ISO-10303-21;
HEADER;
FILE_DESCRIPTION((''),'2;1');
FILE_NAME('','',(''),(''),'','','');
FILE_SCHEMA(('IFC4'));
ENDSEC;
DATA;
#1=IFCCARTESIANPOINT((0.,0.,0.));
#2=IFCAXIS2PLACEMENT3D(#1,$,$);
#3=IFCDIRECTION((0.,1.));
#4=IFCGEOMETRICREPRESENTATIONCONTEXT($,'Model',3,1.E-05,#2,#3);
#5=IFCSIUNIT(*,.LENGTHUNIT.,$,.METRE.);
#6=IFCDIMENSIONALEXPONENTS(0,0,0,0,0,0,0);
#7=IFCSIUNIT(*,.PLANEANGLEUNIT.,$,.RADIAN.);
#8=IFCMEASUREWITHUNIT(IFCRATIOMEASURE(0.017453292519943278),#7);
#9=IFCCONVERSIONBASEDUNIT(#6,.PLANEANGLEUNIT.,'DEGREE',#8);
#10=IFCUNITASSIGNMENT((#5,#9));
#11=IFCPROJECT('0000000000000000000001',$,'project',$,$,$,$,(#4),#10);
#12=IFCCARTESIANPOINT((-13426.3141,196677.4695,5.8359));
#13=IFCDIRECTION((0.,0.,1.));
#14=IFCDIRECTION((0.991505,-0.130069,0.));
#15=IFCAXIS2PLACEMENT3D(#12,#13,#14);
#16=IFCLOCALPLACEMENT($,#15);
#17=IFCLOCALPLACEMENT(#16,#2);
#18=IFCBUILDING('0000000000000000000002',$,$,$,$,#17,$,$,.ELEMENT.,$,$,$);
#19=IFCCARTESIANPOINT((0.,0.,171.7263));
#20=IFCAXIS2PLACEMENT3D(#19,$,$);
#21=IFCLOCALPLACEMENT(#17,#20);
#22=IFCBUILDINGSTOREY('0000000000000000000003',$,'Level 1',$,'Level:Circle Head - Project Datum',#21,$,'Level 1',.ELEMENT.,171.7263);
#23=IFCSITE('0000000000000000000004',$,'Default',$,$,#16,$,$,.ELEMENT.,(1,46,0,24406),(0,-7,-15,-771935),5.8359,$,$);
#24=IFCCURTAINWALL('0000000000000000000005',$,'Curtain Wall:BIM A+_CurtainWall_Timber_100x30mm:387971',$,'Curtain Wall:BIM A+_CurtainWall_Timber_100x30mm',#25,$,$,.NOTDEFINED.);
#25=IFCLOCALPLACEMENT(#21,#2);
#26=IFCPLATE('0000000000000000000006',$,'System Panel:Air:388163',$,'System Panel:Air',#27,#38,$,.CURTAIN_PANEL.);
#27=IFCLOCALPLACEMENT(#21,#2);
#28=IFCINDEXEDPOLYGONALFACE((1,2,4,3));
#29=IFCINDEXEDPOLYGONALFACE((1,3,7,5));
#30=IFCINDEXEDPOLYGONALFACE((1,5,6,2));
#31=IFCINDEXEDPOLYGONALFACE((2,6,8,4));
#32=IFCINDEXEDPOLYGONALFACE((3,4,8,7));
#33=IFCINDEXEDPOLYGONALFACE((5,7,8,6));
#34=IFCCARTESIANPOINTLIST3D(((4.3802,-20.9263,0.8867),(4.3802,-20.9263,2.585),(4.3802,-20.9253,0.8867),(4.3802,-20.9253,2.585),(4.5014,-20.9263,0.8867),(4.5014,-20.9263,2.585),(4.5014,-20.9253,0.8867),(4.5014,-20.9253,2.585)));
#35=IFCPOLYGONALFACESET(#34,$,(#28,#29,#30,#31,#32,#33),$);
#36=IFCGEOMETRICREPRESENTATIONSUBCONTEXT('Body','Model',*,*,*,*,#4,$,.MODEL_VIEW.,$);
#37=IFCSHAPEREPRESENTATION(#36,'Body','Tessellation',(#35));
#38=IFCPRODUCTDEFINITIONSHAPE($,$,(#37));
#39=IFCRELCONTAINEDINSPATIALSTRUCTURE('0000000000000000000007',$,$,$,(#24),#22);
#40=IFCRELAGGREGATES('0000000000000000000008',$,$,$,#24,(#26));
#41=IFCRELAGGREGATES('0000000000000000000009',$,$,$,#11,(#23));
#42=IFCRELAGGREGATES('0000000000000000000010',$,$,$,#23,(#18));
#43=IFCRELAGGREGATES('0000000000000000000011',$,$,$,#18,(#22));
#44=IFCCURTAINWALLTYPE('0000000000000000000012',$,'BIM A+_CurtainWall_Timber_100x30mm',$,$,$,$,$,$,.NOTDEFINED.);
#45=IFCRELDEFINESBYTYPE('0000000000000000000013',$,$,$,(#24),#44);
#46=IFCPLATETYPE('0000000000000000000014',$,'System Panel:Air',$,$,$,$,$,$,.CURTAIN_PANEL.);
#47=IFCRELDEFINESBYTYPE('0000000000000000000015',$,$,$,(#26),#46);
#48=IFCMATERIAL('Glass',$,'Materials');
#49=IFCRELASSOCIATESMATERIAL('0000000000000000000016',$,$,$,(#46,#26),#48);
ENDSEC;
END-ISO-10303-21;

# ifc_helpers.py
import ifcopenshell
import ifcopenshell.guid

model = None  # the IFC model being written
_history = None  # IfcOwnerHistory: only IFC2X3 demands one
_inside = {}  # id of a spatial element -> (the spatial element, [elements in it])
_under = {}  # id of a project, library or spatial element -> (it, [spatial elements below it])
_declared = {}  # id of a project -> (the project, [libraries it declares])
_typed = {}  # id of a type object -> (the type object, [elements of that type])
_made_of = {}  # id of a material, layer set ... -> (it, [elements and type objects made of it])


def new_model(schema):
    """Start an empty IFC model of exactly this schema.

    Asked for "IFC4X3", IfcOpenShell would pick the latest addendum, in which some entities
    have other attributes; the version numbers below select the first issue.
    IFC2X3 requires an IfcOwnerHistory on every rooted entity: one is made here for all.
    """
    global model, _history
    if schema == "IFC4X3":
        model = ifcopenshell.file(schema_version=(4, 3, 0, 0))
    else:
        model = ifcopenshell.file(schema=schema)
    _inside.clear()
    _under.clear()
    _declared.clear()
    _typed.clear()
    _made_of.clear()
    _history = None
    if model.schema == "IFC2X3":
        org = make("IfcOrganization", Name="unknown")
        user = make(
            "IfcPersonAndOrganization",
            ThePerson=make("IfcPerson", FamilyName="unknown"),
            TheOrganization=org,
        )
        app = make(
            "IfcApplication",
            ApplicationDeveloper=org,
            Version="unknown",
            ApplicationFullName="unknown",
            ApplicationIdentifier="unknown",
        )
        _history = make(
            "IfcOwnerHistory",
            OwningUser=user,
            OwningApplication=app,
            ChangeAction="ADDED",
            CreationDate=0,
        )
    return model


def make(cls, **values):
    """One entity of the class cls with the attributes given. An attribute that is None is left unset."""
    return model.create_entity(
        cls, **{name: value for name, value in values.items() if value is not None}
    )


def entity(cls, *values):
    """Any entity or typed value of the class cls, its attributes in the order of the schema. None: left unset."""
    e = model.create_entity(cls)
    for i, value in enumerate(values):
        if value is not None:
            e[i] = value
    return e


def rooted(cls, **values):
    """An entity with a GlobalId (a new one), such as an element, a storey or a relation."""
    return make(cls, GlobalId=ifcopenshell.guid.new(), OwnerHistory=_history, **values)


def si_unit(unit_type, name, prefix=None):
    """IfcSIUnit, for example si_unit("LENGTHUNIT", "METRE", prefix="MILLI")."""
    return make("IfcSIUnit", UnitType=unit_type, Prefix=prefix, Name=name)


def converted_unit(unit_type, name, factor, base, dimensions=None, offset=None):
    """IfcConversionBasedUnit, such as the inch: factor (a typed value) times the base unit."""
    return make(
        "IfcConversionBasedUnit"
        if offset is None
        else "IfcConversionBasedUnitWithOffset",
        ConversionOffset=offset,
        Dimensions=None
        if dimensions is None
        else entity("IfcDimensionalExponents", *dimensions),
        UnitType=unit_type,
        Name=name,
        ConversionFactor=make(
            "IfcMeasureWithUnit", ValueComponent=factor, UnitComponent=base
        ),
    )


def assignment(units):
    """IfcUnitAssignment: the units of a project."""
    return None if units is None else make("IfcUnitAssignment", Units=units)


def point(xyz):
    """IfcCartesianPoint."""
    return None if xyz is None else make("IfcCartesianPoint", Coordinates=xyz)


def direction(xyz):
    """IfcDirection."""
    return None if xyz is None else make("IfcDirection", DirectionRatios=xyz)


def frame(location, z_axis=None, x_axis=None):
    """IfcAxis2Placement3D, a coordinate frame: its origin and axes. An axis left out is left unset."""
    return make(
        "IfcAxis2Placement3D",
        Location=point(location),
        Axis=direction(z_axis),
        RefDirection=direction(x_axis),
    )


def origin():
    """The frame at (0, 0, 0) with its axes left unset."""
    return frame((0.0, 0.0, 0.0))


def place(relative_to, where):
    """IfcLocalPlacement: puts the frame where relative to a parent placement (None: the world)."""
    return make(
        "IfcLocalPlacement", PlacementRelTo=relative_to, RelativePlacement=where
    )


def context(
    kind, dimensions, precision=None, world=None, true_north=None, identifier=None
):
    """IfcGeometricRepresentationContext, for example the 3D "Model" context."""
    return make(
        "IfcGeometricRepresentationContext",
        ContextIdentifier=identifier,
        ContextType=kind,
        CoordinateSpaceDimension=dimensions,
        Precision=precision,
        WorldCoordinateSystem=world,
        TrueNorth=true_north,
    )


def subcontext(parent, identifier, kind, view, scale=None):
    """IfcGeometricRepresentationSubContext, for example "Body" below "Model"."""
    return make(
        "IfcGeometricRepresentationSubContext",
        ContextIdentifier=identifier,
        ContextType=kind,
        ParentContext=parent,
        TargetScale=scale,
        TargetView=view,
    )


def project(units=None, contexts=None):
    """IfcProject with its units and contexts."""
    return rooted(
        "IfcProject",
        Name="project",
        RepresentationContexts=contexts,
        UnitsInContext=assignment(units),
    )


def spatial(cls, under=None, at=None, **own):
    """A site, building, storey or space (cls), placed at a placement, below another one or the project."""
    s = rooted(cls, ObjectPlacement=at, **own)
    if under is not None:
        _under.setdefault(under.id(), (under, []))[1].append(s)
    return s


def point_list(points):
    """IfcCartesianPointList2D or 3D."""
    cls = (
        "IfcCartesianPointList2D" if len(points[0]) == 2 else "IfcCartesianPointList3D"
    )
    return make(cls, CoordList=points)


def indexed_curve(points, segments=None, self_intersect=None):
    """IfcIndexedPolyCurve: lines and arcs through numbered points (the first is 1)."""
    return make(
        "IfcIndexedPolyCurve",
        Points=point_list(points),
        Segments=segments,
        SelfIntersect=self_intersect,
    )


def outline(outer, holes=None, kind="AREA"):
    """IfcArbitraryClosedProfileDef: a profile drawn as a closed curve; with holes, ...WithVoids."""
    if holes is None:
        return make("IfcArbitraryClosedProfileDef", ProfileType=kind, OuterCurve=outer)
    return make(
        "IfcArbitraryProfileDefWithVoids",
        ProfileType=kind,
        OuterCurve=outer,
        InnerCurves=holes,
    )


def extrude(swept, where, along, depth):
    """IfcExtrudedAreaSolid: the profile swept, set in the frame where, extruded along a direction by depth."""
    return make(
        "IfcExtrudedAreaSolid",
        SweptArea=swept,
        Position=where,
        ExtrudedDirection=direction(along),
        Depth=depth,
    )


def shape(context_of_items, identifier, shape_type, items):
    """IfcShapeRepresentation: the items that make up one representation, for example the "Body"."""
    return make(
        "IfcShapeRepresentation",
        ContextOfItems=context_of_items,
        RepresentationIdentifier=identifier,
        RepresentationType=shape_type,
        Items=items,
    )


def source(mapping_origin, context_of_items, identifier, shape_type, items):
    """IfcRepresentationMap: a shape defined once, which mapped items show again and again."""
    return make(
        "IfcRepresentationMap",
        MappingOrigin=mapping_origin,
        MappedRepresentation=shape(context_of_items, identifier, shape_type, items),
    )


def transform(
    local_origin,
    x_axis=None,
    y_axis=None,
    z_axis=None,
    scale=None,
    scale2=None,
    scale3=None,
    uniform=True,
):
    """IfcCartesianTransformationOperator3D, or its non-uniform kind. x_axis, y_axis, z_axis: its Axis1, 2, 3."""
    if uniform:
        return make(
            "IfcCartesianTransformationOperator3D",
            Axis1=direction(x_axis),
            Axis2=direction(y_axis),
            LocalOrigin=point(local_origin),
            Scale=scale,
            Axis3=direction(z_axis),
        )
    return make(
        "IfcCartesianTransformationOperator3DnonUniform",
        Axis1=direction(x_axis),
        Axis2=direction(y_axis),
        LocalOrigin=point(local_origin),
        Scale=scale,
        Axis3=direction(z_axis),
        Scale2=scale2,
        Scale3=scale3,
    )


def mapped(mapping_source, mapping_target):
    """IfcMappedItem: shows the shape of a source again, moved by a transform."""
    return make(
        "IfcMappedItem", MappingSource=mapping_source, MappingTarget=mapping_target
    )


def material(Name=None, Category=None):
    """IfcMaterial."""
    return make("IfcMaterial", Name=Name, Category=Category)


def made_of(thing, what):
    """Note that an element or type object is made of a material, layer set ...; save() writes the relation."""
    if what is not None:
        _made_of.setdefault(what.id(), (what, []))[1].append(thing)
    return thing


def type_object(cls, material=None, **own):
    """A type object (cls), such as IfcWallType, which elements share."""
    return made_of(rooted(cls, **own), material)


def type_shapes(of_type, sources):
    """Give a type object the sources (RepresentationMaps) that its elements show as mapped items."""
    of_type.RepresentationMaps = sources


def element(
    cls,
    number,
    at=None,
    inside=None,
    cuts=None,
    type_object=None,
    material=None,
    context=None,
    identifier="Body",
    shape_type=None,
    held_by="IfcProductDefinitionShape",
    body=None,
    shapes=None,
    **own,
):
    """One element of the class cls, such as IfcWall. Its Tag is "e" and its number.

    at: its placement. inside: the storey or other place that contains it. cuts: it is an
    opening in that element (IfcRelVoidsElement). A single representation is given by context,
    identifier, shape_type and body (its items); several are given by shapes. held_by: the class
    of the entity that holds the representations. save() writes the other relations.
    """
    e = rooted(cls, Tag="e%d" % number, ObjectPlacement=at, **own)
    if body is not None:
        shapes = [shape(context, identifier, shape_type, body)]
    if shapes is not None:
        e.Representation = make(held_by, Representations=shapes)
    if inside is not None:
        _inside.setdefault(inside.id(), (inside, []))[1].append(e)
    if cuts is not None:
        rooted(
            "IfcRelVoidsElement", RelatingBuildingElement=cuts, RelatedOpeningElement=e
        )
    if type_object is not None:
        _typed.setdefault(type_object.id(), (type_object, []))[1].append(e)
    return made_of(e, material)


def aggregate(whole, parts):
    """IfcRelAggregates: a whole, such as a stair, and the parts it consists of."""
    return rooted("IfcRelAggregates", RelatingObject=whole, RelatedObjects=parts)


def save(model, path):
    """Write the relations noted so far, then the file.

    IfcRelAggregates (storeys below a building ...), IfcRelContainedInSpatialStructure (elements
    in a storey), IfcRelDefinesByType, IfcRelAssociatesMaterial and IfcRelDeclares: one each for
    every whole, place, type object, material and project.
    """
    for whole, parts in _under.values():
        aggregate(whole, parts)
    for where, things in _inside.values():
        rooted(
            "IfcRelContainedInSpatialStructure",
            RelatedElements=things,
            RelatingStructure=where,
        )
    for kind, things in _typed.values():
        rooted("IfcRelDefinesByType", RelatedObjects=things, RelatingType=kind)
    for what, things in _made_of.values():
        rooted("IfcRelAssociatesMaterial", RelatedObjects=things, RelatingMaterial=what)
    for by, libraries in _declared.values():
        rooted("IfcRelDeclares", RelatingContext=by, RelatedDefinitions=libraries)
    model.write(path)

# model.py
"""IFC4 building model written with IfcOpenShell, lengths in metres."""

from ifc_helpers import new_model, entity, si_unit, converted_unit, direction, frame, origin, place, context, subcontext, project, spatial, indexed_curve, outline, extrude, source, transform, mapped, material, type_object, type_shapes, element, aggregate, save


model = new_model("IFC4")

# Units and contexts
model_context = context("Model", 3, precision=1e-05, world=origin(), true_north=direction((0.0, 1.0)))
body_context = subcontext(model_context, "Body", "Model", "MODEL_VIEW")
ifc_project = project(units=[si_unit("LENGTHUNIT", "METRE"), converted_unit("PLANEANGLEUNIT", "DEGREE", entity("IfcRatioMeasure", 0.017453292519943278), si_unit("PLANEANGLEUNIT", "RADIAN"), dimensions=[0, 0, 0, 0, 0, 0, 0])], contexts=[model_context])

# Site, building, storey
site_placement = place(None, frame((-13426.3141, 196677.4695, 5.8359), z_axis=(0.0, 0.0, 1.0), x_axis=(0.991505, -0.130069, 0.0)))
site = spatial("IfcSite", under=ifc_project, at=site_placement, Name="Default", CompositionType="ELEMENT", RefLatitude=(1, 46, 0, 24406), RefLongitude=(0, -7, -15, -771935), RefElevation=5.8359)
building_placement = place(site_placement, origin())
building = spatial("IfcBuilding", under=site, at=building_placement, CompositionType="ELEMENT")
storey_placement = place(building_placement, frame((0.0, 0.0, 171.7263)))
storey = spatial("IfcBuildingStorey", under=building, at=storey_placement, Name="Level 1", ObjectType="Level:Circle Head - Project Datum", LongName="Level 1", CompositionType="ELEMENT", Elevation=171.7263)

# Curtain wall
curtain_wall_type_1 = type_object("IfcCurtainWallType", Name="BIM A+_CurtainWall_Timber_100x30mm", PredefinedType="NOTDEFINED")
curtain_wall_1_placement = place(storey_placement, frame((0.0, 0.0, -171.7263)))
curtain_wall_1 = element("IfcCurtainWall", 1, at=curtain_wall_1_placement, inside=storey, type_object=curtain_wall_type_1, Name="Curtain Wall:BIM A+_CurtainWall_Timber_100x30mm:387971", ObjectType="Curtain Wall:BIM A+_CurtainWall_Timber_100x30mm", PredefinedType="NOTDEFINED")

# Plate
ifc_material_1 = material(Name="Glass", Category="Materials")
plate_type_1 = type_object("IfcPlateType", Name="System Panel:Air", PredefinedType="CURTAIN_PANEL", material=ifc_material_1)
shared_shape_1 = source(origin(), body_context, "Body", "SweptSolid", [
    extrude(outline(indexed_curve([(-0.0005, -0.0606), (0.0005, -0.0606), (0.0005, 0.0606), (-0.0005, 0.0606), (-0.0005, -0.0606)], self_intersect=False)), frame((0.0, 0.0, 0.0), z_axis=(0.0, 0.0, 1.0), x_axis=(0.0, 1.0, 0.0)), (0.0, 0.0, 1.0), 1.6983),
])
type_shapes(plate_type_1, [shared_shape_1])
plate_1_placement = place(curtain_wall_1_placement, frame((4.4408, -20.9258, 172.613)))
plate_1 = element("IfcPlate", 2, at=plate_1_placement, type_object=plate_type_1, material=ifc_material_1, Name="System Panel:Air:388163", ObjectType="System Panel:Air", PredefinedType="CURTAIN_PANEL", context=body_context, shape_type="MappedRepresentation", body=[
    mapped(shared_shape_1, transform((0.0, 0.0, 0.0), scale=1.0)),
])
aggregate(curtain_wall_1, [plate_1])

save(model, "model.ifc")
